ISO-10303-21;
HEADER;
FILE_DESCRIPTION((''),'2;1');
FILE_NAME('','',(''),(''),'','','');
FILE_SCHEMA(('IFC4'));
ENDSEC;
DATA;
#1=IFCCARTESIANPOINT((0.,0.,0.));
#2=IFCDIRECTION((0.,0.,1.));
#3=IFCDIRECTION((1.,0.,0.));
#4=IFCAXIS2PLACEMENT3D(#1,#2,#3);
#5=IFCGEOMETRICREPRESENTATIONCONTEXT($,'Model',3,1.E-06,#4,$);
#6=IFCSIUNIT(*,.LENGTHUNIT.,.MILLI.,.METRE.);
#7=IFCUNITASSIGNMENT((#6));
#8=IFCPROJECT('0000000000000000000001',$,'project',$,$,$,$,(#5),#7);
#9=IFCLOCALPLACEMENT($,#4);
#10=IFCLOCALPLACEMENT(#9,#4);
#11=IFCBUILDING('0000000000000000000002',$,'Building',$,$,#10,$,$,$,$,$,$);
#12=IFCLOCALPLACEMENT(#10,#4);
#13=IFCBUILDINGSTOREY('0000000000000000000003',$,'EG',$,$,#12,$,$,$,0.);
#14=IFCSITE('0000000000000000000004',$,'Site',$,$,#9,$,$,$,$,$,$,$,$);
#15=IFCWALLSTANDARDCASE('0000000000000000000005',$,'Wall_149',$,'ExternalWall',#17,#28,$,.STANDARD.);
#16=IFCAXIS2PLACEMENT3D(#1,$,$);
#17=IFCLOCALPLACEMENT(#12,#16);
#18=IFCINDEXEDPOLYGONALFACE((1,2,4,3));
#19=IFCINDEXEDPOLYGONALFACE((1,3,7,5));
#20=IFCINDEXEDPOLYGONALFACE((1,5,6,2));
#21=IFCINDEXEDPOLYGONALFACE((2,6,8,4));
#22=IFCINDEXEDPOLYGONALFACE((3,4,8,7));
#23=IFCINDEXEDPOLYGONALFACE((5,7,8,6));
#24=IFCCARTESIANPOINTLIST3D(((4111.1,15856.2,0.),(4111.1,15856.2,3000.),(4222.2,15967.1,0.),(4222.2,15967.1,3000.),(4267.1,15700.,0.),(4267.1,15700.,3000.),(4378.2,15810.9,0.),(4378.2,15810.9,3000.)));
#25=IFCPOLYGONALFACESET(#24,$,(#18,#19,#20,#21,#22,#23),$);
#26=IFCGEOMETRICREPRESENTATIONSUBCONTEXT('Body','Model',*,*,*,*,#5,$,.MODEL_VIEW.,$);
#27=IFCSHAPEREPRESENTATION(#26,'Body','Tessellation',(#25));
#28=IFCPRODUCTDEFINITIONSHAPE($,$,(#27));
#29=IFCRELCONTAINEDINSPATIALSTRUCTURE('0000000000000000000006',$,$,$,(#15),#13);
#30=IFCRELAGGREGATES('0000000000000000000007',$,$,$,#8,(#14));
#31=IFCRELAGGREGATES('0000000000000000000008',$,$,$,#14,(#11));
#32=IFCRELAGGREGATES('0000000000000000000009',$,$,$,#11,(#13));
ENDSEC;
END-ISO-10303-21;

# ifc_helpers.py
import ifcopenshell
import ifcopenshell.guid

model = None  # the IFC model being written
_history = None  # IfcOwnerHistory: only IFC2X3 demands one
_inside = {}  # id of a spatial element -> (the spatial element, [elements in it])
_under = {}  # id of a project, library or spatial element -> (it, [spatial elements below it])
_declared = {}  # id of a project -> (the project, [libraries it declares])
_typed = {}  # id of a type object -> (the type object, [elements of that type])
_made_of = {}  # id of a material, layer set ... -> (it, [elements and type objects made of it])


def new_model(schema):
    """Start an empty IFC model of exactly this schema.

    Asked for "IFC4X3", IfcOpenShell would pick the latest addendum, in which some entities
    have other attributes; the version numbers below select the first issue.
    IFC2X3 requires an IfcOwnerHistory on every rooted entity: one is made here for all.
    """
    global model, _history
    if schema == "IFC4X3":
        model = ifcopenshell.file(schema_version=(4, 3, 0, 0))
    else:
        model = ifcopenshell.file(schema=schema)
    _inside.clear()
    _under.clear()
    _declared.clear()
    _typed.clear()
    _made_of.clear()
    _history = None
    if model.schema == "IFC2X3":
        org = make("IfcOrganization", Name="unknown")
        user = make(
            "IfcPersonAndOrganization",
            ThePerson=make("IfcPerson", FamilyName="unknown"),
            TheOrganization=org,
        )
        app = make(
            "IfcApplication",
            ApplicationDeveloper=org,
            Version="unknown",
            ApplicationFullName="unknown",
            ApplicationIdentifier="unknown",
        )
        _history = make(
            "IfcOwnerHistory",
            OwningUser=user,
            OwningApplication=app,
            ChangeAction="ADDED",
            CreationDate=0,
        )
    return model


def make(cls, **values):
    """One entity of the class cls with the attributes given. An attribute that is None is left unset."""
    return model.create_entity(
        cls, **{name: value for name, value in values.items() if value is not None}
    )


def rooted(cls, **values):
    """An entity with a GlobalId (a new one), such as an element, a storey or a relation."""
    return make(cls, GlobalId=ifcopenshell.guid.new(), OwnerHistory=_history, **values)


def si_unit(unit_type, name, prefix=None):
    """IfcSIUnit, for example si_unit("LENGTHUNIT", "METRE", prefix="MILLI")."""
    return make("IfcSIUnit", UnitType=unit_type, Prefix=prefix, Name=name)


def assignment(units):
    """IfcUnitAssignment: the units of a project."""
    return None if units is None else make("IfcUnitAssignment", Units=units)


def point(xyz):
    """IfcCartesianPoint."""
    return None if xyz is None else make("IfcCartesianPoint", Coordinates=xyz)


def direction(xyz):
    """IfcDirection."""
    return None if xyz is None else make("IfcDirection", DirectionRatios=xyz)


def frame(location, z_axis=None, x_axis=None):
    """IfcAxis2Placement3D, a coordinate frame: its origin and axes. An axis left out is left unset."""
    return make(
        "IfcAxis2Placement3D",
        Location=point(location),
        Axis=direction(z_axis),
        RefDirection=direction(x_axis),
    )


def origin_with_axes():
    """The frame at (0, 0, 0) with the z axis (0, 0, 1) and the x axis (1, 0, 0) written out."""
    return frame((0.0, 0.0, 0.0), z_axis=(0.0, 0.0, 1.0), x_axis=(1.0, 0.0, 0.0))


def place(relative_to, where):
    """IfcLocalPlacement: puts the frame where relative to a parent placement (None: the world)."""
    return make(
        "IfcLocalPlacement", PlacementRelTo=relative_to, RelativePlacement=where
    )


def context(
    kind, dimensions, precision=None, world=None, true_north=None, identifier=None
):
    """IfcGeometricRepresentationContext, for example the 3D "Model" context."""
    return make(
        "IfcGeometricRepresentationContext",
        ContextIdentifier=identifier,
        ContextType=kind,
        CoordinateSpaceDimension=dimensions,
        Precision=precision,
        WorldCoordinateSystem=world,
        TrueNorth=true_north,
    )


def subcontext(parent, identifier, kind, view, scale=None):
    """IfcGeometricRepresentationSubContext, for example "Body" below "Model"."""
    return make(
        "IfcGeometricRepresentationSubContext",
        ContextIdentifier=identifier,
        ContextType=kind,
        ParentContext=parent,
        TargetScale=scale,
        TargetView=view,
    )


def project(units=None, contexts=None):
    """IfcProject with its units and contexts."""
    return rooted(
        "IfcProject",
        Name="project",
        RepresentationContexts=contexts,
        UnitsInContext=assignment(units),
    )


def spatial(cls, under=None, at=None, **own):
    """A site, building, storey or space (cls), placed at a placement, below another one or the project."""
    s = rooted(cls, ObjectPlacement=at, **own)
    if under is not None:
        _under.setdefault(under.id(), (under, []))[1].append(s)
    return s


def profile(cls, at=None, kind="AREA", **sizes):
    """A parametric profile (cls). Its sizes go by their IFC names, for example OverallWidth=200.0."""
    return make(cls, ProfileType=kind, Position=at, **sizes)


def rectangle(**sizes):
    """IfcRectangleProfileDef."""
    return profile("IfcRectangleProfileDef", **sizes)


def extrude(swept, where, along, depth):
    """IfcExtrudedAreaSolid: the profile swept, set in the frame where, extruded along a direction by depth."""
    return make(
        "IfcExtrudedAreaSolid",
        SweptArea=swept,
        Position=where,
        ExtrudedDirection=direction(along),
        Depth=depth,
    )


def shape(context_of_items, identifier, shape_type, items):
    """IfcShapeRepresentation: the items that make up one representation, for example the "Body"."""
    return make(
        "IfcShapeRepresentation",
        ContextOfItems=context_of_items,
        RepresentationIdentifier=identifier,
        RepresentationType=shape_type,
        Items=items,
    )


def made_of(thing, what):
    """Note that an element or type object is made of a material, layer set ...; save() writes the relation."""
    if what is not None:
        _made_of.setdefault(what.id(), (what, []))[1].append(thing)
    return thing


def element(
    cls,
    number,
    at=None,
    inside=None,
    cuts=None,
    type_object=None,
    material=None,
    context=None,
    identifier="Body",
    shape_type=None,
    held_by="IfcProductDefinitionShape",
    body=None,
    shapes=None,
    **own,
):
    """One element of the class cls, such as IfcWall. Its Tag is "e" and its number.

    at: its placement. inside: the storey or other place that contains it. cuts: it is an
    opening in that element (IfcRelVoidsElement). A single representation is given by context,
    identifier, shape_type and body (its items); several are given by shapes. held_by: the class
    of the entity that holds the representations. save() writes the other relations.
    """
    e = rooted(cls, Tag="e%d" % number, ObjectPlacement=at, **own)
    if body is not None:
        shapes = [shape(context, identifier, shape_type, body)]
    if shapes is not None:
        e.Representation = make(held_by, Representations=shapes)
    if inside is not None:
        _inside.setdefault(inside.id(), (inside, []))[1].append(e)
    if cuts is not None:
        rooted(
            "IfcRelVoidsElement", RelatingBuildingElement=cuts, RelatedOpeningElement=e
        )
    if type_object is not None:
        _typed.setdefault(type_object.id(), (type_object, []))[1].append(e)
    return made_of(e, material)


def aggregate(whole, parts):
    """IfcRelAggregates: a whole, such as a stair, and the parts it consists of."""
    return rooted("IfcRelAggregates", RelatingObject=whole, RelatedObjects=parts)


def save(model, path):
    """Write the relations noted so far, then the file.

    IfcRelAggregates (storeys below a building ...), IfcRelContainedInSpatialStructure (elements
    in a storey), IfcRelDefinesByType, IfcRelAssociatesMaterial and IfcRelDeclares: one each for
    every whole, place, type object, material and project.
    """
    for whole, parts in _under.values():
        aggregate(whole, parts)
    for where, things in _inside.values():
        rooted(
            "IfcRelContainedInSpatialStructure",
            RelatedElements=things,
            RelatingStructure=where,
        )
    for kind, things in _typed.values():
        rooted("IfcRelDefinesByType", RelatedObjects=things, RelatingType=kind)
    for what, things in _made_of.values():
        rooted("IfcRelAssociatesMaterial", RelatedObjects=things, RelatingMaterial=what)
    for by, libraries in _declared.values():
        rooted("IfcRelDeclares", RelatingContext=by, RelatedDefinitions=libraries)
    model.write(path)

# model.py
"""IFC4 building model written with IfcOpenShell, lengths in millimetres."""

from ifc_helpers import new_model, si_unit, frame, origin_with_axes, place, context, subcontext, project, spatial, rectangle, extrude, element, save


model = new_model("IFC4")

# Units and contexts
model_context = context("Model", 3, precision=1e-06, world=origin_with_axes())
body_context = subcontext(model_context, "Body", "Model", "MODEL_VIEW")
ifc_project = project(units=[si_unit("LENGTHUNIT", "METRE", prefix="MILLI")], contexts=[model_context])

# Site, building, storey
site_placement = place(None, origin_with_axes())
site = spatial("IfcSite", under=ifc_project, at=site_placement, Name="Site")
building_placement = place(site_placement, origin_with_axes())
building = spatial("IfcBuilding", under=site, at=building_placement, Name="Building")
storey_placement = place(building_placement, origin_with_axes())
storey = spatial("IfcBuildingStorey", under=building, at=storey_placement, Name="EG", Elevation=0.0)

# Wall
wall_1_placement = place(storey_placement, origin_with_axes())
element("IfcWallStandardCase", 1, at=wall_1_placement, inside=storey, Name="Wall_149", ObjectType="ExternalWall", PredefinedType="STANDARD", context=body_context, shape_type="SweptSolid", body=[
    extrude(rectangle(XDim=220.8, YDim=157.0), frame((4244.7, 15833.5, 0.0), z_axis=(0.0, 0.0, 1.0), x_axis=(-0.70654, 0.707673, 0.0)), (0.0, 0.0, 1.0), 3000.0),
])

save(model, "model.ifc")
